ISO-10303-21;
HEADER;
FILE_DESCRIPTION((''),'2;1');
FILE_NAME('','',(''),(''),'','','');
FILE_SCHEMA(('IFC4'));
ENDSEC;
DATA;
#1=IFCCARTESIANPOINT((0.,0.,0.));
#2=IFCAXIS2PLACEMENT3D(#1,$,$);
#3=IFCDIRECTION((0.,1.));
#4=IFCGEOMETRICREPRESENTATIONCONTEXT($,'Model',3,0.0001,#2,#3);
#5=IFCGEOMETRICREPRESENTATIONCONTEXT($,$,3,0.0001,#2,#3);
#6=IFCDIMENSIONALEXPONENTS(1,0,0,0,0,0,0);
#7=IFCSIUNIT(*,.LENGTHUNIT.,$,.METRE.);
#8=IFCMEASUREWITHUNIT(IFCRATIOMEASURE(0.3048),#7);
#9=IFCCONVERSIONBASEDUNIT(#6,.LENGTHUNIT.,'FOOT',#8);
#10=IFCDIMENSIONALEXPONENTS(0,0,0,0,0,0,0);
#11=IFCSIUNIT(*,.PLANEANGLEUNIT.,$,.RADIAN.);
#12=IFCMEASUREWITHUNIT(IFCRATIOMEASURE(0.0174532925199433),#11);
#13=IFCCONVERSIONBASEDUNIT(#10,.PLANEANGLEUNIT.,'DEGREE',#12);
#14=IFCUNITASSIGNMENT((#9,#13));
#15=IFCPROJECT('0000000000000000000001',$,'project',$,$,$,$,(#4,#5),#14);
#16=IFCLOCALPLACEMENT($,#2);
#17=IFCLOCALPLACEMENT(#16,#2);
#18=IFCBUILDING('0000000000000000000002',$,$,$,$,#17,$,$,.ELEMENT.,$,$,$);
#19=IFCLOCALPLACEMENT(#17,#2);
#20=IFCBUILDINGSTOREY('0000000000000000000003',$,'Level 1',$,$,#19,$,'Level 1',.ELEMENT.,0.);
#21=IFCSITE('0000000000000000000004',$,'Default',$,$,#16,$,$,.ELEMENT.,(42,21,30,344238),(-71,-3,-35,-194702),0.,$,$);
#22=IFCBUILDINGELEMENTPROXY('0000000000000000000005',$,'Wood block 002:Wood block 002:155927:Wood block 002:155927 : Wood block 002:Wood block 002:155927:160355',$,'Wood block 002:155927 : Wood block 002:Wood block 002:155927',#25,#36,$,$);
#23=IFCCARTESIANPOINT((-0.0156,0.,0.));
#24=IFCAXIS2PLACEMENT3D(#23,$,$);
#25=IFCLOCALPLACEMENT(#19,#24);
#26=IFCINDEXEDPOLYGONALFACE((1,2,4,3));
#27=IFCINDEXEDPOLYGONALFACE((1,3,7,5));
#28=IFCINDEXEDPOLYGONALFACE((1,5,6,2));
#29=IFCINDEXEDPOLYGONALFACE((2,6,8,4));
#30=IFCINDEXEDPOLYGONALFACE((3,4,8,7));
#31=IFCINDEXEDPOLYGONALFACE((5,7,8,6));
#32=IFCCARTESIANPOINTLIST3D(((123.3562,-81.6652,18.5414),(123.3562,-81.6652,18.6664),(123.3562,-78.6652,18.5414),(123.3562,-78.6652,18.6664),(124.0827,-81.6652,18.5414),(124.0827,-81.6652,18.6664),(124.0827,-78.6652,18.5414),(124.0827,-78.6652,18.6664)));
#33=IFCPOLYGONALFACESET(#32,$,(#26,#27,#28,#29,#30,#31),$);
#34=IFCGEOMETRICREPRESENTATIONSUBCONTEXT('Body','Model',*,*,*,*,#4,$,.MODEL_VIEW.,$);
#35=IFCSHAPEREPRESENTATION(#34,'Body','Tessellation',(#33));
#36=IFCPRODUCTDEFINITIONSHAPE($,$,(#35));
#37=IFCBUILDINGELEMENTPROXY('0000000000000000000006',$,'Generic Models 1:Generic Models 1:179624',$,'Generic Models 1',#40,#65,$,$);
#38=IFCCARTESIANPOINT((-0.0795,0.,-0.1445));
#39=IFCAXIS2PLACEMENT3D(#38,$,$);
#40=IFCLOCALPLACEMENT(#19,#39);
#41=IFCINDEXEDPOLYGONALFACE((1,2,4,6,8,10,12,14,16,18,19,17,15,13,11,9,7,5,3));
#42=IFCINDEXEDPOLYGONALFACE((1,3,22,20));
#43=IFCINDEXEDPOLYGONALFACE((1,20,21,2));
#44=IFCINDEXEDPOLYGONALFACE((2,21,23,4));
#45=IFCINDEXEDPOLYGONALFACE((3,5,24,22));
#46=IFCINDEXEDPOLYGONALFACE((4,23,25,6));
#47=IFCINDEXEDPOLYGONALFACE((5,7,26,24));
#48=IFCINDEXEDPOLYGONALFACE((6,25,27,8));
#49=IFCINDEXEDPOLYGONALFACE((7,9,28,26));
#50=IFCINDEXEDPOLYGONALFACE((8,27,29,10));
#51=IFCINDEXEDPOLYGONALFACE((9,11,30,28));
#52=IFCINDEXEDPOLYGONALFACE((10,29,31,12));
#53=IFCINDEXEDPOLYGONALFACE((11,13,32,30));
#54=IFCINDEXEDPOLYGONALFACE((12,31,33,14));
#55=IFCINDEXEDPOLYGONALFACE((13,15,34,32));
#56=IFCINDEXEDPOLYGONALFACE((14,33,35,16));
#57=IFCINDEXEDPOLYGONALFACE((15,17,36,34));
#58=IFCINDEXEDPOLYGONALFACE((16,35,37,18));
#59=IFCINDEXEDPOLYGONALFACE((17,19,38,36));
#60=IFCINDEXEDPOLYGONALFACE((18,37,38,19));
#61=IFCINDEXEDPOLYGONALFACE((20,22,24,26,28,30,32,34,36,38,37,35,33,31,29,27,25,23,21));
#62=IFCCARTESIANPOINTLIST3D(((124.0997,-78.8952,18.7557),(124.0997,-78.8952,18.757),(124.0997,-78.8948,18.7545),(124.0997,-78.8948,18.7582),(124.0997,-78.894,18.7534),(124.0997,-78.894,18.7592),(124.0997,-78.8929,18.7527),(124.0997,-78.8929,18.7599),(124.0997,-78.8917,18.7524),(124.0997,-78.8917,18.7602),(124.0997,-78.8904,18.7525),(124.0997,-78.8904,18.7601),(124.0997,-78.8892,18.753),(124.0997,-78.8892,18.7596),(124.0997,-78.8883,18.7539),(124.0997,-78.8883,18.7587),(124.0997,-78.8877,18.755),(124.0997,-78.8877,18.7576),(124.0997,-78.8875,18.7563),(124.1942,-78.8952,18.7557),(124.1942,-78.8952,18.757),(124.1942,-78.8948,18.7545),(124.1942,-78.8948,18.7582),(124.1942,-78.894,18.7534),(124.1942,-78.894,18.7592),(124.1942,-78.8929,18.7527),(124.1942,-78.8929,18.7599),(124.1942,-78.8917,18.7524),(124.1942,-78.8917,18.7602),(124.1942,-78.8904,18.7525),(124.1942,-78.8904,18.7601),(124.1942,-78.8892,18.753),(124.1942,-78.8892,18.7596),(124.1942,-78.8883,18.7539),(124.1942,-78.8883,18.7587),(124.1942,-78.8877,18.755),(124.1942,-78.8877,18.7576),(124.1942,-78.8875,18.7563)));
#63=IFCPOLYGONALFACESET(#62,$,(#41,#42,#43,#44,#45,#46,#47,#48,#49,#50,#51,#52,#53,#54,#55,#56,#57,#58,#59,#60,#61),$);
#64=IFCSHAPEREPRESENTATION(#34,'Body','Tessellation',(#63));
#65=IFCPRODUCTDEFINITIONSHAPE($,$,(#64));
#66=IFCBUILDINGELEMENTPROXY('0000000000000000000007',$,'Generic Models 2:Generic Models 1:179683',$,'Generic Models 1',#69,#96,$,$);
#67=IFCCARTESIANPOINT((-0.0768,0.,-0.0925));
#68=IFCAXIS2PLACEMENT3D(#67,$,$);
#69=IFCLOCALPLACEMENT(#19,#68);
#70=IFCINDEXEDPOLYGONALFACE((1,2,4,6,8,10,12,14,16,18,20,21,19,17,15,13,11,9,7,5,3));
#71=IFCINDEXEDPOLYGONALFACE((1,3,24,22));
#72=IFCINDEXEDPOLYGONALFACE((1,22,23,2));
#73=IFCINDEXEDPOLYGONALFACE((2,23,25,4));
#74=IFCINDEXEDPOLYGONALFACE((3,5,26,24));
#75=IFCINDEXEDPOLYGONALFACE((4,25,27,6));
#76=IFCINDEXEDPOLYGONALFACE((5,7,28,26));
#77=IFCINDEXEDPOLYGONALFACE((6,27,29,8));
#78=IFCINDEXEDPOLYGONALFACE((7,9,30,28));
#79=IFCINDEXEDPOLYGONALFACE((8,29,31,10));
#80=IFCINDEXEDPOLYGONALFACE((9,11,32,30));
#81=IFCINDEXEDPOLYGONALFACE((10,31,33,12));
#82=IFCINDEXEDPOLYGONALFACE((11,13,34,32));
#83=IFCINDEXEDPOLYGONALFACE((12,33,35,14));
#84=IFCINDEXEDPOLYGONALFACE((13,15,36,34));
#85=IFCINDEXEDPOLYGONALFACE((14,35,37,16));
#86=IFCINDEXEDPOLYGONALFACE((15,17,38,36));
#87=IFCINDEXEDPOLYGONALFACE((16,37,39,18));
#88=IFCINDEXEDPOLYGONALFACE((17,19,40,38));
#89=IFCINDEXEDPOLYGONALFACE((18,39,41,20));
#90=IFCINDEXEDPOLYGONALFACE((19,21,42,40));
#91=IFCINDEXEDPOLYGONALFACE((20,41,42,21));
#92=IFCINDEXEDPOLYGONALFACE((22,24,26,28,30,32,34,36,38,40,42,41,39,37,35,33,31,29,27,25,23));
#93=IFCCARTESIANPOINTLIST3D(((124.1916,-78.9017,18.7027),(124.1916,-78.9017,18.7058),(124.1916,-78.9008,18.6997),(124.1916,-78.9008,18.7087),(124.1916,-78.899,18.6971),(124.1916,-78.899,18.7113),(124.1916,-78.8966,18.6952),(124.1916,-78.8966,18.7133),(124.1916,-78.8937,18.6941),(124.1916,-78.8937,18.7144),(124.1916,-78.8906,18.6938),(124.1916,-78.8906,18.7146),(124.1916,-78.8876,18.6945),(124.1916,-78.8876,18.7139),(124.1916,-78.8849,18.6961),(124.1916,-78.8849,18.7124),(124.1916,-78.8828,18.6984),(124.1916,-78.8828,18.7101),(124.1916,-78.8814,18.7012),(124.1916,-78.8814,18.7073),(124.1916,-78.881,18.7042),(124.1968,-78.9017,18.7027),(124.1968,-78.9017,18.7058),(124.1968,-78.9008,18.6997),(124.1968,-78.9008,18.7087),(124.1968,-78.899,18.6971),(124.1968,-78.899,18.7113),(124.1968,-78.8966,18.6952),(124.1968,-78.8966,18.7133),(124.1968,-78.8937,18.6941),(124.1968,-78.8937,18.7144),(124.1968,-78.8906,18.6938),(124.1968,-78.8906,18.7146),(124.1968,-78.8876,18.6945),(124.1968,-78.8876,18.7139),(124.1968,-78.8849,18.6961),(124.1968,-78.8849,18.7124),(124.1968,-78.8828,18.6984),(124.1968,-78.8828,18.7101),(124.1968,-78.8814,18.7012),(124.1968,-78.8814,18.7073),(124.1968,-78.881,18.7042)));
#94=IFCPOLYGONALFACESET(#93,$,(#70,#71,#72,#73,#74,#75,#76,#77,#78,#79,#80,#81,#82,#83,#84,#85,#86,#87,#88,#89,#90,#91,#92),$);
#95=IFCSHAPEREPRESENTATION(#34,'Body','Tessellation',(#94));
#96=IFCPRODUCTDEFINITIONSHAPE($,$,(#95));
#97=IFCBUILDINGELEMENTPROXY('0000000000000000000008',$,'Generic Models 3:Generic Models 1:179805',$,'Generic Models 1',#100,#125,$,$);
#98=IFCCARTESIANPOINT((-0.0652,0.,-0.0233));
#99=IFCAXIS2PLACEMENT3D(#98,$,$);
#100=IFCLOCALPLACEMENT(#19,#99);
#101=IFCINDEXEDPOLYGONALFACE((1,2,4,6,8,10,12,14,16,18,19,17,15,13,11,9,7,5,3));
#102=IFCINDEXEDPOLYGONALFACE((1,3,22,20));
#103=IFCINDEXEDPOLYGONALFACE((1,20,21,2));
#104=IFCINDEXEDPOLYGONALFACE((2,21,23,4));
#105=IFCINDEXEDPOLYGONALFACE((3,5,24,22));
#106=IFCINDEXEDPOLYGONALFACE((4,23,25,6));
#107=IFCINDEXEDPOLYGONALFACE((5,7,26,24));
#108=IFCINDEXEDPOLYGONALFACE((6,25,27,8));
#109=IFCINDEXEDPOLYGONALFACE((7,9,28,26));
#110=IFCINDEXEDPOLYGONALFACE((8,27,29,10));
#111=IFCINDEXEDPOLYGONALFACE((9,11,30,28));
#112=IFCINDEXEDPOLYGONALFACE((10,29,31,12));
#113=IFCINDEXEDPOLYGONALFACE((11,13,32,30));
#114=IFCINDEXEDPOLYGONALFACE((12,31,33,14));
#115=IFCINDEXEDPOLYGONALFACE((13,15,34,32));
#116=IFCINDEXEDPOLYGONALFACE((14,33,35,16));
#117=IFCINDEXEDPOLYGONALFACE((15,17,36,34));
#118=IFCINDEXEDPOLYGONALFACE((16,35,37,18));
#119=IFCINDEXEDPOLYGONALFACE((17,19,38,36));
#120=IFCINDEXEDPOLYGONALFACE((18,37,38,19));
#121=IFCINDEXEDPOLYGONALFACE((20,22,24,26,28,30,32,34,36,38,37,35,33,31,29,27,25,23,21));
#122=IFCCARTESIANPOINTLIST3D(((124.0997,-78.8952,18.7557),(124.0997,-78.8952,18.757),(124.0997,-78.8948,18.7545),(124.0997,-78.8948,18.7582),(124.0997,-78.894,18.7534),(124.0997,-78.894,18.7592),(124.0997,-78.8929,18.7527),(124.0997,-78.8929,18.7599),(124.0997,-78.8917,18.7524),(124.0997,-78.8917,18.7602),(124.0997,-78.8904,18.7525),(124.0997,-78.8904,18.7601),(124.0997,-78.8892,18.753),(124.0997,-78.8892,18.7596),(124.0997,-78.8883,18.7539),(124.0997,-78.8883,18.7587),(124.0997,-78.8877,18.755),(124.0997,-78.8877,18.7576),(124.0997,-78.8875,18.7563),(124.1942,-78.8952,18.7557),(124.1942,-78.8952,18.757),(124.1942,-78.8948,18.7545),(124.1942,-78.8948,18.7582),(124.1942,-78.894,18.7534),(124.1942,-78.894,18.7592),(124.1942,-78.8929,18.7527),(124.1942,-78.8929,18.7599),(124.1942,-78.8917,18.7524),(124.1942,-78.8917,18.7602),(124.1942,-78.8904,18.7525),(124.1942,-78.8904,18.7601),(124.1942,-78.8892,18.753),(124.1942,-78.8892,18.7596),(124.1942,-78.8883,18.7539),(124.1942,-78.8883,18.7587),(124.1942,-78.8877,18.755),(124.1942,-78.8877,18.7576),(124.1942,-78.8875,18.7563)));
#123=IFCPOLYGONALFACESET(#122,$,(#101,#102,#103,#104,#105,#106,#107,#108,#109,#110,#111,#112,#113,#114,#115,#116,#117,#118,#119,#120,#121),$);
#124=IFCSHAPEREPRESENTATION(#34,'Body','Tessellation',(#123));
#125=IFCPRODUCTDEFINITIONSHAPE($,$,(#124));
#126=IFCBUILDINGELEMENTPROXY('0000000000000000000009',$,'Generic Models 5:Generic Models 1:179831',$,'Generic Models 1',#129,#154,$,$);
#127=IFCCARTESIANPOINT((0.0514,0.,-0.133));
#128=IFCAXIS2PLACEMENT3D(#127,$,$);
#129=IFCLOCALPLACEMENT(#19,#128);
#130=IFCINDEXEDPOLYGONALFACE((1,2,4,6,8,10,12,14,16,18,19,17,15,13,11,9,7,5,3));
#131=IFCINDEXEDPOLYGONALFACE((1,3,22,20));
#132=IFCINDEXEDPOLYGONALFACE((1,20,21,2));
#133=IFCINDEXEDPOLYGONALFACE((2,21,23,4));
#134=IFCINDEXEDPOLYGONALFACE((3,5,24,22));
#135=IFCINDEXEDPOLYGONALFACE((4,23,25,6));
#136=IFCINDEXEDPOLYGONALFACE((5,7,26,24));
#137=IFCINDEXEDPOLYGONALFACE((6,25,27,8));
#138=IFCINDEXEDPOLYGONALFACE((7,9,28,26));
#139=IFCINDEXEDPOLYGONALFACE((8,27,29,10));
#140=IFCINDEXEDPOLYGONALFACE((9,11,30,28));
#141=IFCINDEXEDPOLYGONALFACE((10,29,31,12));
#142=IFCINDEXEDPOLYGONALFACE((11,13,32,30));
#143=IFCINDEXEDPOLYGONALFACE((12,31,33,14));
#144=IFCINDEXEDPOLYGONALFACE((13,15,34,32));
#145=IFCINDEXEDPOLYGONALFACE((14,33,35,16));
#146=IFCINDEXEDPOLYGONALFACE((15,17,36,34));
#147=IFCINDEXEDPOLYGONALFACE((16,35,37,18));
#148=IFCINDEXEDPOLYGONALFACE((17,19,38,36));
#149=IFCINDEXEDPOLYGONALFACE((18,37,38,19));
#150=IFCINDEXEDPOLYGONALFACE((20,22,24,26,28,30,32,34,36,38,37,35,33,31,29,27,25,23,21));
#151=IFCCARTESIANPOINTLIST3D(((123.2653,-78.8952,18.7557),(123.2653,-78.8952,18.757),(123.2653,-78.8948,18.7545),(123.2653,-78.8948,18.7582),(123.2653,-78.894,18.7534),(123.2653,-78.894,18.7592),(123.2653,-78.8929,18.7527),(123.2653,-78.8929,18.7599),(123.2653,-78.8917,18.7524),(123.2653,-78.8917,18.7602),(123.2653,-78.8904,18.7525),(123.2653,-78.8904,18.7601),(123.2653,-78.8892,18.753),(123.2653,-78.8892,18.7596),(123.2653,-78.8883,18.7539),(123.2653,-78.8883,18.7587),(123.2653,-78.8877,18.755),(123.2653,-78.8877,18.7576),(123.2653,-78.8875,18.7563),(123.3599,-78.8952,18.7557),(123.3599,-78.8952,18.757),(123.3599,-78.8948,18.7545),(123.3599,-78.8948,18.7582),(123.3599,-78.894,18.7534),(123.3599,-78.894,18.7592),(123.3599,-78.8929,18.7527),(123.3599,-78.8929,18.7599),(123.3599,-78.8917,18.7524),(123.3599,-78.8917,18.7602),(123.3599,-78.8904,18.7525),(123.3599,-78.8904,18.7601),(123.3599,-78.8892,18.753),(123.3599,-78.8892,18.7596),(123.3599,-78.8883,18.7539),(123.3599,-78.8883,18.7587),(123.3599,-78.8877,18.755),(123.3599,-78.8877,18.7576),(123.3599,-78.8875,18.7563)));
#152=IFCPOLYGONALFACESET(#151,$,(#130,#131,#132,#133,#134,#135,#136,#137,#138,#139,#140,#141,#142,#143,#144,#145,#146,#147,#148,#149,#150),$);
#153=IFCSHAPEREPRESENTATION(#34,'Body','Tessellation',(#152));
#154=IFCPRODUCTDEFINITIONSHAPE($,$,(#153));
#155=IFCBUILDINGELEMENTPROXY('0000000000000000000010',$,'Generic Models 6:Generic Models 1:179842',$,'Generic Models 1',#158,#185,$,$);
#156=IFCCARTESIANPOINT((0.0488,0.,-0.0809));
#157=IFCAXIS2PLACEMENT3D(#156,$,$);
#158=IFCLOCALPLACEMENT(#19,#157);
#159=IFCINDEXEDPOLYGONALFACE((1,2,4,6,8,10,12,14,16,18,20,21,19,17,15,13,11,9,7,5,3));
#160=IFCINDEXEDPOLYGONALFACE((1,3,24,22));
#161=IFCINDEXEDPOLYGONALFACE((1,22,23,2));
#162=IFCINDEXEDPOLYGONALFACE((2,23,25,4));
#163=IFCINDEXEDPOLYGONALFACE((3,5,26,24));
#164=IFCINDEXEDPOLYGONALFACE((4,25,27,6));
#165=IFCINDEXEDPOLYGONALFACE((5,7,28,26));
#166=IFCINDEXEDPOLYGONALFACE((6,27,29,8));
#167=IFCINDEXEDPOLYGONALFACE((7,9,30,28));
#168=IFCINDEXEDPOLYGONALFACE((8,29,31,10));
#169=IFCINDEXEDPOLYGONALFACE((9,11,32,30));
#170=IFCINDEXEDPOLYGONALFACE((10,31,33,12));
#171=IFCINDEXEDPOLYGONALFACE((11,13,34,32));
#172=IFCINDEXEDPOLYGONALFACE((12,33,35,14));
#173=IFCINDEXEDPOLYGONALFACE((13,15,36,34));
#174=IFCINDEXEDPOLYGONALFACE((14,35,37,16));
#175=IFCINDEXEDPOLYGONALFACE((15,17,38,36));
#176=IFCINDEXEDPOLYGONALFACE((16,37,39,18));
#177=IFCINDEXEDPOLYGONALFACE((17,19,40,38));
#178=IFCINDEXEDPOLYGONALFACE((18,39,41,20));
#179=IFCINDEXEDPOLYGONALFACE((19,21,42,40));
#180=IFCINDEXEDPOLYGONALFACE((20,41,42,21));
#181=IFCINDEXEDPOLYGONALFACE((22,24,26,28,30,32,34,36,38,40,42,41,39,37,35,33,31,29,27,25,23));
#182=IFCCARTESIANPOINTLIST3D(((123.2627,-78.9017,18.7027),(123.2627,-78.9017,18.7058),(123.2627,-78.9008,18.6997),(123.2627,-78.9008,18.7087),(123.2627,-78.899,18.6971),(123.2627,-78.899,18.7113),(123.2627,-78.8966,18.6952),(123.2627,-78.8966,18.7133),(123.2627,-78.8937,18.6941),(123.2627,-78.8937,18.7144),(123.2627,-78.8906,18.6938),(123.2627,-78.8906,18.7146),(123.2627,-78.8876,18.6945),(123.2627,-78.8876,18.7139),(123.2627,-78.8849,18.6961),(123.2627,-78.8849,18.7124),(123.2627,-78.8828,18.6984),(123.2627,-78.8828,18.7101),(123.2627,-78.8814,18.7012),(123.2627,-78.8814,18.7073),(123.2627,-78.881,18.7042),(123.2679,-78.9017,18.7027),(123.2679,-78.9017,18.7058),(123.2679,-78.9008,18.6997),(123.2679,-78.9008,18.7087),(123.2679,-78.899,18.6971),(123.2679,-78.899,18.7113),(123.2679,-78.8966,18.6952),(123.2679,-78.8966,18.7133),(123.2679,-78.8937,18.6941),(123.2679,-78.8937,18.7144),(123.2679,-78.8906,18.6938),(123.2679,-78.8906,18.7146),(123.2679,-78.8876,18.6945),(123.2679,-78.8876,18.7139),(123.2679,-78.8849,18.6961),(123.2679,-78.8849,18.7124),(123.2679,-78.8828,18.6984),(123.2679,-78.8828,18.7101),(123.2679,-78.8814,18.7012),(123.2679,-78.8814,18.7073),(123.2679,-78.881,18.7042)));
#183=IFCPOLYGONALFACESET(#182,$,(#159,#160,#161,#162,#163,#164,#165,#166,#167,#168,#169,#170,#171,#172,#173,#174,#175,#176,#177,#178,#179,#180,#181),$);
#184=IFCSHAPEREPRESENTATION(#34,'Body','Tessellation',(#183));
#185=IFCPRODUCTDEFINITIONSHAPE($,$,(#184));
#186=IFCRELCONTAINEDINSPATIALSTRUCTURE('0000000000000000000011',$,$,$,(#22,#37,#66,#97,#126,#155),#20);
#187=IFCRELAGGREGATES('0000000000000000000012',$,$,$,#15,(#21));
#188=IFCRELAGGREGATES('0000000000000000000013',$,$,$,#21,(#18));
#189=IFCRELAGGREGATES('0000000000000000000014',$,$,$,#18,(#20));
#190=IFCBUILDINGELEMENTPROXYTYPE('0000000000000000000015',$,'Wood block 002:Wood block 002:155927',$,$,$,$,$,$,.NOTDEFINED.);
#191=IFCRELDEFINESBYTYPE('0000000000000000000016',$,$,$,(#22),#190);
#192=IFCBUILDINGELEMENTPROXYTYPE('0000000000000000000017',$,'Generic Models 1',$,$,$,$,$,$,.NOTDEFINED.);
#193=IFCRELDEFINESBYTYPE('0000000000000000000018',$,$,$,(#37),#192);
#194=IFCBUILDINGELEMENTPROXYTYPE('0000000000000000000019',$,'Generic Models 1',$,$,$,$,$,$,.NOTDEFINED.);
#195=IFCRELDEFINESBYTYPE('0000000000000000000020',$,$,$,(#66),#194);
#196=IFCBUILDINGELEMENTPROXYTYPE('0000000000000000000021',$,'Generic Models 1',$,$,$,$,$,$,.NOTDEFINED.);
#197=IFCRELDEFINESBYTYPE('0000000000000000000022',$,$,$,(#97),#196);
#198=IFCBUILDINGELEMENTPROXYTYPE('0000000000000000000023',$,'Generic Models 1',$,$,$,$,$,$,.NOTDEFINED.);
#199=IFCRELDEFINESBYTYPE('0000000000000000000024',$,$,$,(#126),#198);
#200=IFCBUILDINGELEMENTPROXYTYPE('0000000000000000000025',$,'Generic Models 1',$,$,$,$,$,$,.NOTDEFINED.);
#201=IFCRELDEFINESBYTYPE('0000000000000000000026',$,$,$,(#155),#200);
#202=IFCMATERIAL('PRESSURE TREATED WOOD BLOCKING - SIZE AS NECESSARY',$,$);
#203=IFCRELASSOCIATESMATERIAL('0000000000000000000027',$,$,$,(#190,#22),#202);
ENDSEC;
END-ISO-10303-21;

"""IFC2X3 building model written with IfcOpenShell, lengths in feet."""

from ifc_helpers import new_model, entity, si_unit, converted_unit, direction, frame, frame_2d, origin, origin_2d_with_axis, place, context, subcontext, project, spatial, rectangle, circle, extrude, source, transform, mapped, material, type_object, type_shapes, element, save


model = new_model("IFC2X3")

# Units and contexts
model_context = context("Model", 3, precision=0.0001, world=origin(), true_north=direction((0.0, 1.0)))
context_of_model = context(None, 3, precision=0.0001, world=origin(), true_north=direction((0.0, 1.0)))
body_context = subcontext(model_context, "Body", "Model", "MODEL_VIEW")
ifc_project = project(units=[converted_unit("LENGTHUNIT", "FOOT", entity("IfcRatioMeasure", 0.3048), si_unit("LENGTHUNIT", "METRE"), dimensions=[1, 0, 0, 0, 0, 0, 0]), converted_unit("PLANEANGLEUNIT", "DEGREE", entity("IfcRatioMeasure", 0.0174532925199433), si_unit("PLANEANGLEUNIT", "RADIAN"), dimensions=[0, 0, 0, 0, 0, 0, 0])], contexts=[model_context, context_of_model])

# Site, building, storey
site_placement = place(None, origin())
site = spatial("IfcSite", under=ifc_project, at=site_placement, Name="Default", CompositionType="ELEMENT", RefLatitude=(42, 21, 30, 344238), RefLongitude=(-71, -3, -35, -194702), RefElevation=0.0)
building_placement = place(site_placement, origin())
building = spatial("IfcBuilding", under=site, at=building_placement, CompositionType="ELEMENT")
storey_placement = place(building_placement, origin())
storey = spatial("IfcBuildingStorey", under=building, at=storey_placement, Name="Level 1", LongName="Level 1", CompositionType="ELEMENT", Elevation=0.0)

# Building element proxies
ifc_material_1 = material(Name="PRESSURE TREATED WOOD BLOCKING - SIZE AS NECESSARY")
building_element_proxy_type_1 = type_object("IfcBuildingElementProxyType", Name="Wood block 002:Wood block 002:155927", PredefinedType="NOTDEFINED", material=ifc_material_1)
shared_shape_1 = source(origin(), body_context, "Body", "SweptSolid", [
    extrude(rectangle(XDim=3.0, YDim=0.7265, at=frame_2d((0.0, 0.0), x_axis=(1.0, 0.0))), frame((123.7194, -80.1652, 18.5414), z_axis=(0.0, 0.0, 1.0), x_axis=(0.0, -1.0, 0.0)), (0.0, 0.0, 1.0), 0.125),
])
type_shapes(building_element_proxy_type_1, [shared_shape_1])
proxy_1_placement = place(storey_placement, frame((-0.0156, 0.0, 0.0)))
element("IfcBuildingElementProxy", 1, at=proxy_1_placement, inside=storey, type_object=building_element_proxy_type_1, material=ifc_material_1, Name="Wood block 002:Wood block 002:155927:Wood block 002:155927 : Wood block 002:Wood block 002:155927:160355", ObjectType="Wood block 002:155927 : Wood block 002:Wood block 002:155927", context=body_context, shape_type="MappedRepresentation", body=[
    mapped(shared_shape_1, transform((0.0, 0.0, 0.0), scale=1.0)),
])
building_element_proxy_type_2 = type_object("IfcBuildingElementProxyType", Name="Generic Models 1", PredefinedType="NOTDEFINED")
shared_shape_2 = source(origin(), body_context, "Body", "SweptSolid", [
    extrude(circle(Radius=0.0039, at=origin_2d_with_axis()), frame((124.0997, -78.8914, 18.7563), z_axis=(1.0, 0.0, 0.0), x_axis=(0.0, 1.0, 0.0)), (0.0, 0.0, 1.0), 0.0945),
])
type_shapes(building_element_proxy_type_2, [shared_shape_2])
proxy_2_placement = place(storey_placement, frame((-0.0795, 0.0, -0.1445)))
element("IfcBuildingElementProxy", 2, at=proxy_2_placement, inside=storey, type_object=building_element_proxy_type_2, Name="Generic Models 1:Generic Models 1:179624", ObjectType="Generic Models 1", context=body_context, shape_type="MappedRepresentation", body=[
    mapped(shared_shape_2, transform((0.0, 0.0, 0.0), scale=1.0)),
])
building_element_proxy_type_3 = type_object("IfcBuildingElementProxyType", Name="Generic Models 1", PredefinedType="NOTDEFINED")
shared_shape_3 = source(origin(), body_context, "Body", "SweptSolid", [
    extrude(circle(Radius=0.0104, at=origin_2d_with_axis()), frame((124.1916, -78.8914, 18.7042), z_axis=(1.0, 0.0, 0.0), x_axis=(0.0, 1.0, 0.0)), (0.0, 0.0, 1.0), 0.0052),
])
type_shapes(building_element_proxy_type_3, [shared_shape_3])
proxy_3_placement = place(storey_placement, frame((-0.0768, 0.0, -0.0925)))
element("IfcBuildingElementProxy", 3, at=proxy_3_placement, inside=storey, type_object=building_element_proxy_type_3, Name="Generic Models 2:Generic Models 1:179683", ObjectType="Generic Models 1", context=body_context, shape_type="MappedRepresentation", body=[
    mapped(shared_shape_3, transform((0.0, 0.0, 0.0), scale=1.0)),
])
building_element_proxy_type_4 = type_object("IfcBuildingElementProxyType", Name="Generic Models 1", PredefinedType="NOTDEFINED")
shared_shape_4 = source(origin(), body_context, "Body", "SweptSolid", [
    extrude(circle(Radius=0.0039, at=origin_2d_with_axis()), frame((124.0997, -78.8914, 18.7563), z_axis=(1.0, 0.0, 0.0), x_axis=(0.0, 1.0, 0.0)), (0.0, 0.0, 1.0), 0.0945),
])
type_shapes(building_element_proxy_type_4, [shared_shape_4])
proxy_4_placement = place(storey_placement, frame((-0.0652, 0.0, -0.0233)))
element("IfcBuildingElementProxy", 4, at=proxy_4_placement, inside=storey, type_object=building_element_proxy_type_4, Name="Generic Models 3:Generic Models 1:179805", ObjectType="Generic Models 1", context=body_context, shape_type="MappedRepresentation", body=[
    mapped(shared_shape_4, transform((0.0, 0.0, 0.0), scale=1.0)),
])
building_element_proxy_type_5 = type_object("IfcBuildingElementProxyType", Name="Generic Models 1", PredefinedType="NOTDEFINED")
shared_shape_5 = source(origin(), body_context, "Body", "SweptSolid", [
    extrude(circle(Radius=0.0039, at=origin_2d_with_axis()), frame((123.2653, -78.8914, 18.7563), z_axis=(1.0, 0.0, 0.0), x_axis=(0.0, 1.0, 0.0)), (0.0, 0.0, 1.0), 0.0945),
])
type_shapes(building_element_proxy_type_5, [shared_shape_5])
proxy_5_placement = place(storey_placement, frame((0.0514, 0.0, -0.133)))
element("IfcBuildingElementProxy", 5, at=proxy_5_placement, inside=storey, type_object=building_element_proxy_type_5, Name="Generic Models 5:Generic Models 1:179831", ObjectType="Generic Models 1", context=body_context, shape_type="MappedRepresentation", body=[
    mapped(shared_shape_5, transform((0.0, 0.0, 0.0), scale=1.0)),
])
building_element_proxy_type_6 = type_object("IfcBuildingElementProxyType", Name="Generic Models 1", PredefinedType="NOTDEFINED")
shared_shape_6 = source(origin(), body_context, "Body", "SweptSolid", [
    extrude(circle(Radius=0.0104, at=origin_2d_with_axis()), frame((123.2627, -78.8914, 18.7042), z_axis=(1.0, 0.0, 0.0), x_axis=(0.0, 1.0, 0.0)), (0.0, 0.0, 1.0), 0.0052),
])
type_shapes(building_element_proxy_type_6, [shared_shape_6])
proxy_6_placement = place(storey_placement, frame((0.0488, 0.0, -0.0809)))
element("IfcBuildingElementProxy", 6, at=proxy_6_placement, inside=storey, type_object=building_element_proxy_type_6, Name="Generic Models 6:Generic Models 1:179842", ObjectType="Generic Models 1", context=body_context, shape_type="MappedRepresentation", body=[
    mapped(shared_shape_6, transform((0.0, 0.0, 0.0), scale=1.0)),
])

save(model, "model.ifc")
